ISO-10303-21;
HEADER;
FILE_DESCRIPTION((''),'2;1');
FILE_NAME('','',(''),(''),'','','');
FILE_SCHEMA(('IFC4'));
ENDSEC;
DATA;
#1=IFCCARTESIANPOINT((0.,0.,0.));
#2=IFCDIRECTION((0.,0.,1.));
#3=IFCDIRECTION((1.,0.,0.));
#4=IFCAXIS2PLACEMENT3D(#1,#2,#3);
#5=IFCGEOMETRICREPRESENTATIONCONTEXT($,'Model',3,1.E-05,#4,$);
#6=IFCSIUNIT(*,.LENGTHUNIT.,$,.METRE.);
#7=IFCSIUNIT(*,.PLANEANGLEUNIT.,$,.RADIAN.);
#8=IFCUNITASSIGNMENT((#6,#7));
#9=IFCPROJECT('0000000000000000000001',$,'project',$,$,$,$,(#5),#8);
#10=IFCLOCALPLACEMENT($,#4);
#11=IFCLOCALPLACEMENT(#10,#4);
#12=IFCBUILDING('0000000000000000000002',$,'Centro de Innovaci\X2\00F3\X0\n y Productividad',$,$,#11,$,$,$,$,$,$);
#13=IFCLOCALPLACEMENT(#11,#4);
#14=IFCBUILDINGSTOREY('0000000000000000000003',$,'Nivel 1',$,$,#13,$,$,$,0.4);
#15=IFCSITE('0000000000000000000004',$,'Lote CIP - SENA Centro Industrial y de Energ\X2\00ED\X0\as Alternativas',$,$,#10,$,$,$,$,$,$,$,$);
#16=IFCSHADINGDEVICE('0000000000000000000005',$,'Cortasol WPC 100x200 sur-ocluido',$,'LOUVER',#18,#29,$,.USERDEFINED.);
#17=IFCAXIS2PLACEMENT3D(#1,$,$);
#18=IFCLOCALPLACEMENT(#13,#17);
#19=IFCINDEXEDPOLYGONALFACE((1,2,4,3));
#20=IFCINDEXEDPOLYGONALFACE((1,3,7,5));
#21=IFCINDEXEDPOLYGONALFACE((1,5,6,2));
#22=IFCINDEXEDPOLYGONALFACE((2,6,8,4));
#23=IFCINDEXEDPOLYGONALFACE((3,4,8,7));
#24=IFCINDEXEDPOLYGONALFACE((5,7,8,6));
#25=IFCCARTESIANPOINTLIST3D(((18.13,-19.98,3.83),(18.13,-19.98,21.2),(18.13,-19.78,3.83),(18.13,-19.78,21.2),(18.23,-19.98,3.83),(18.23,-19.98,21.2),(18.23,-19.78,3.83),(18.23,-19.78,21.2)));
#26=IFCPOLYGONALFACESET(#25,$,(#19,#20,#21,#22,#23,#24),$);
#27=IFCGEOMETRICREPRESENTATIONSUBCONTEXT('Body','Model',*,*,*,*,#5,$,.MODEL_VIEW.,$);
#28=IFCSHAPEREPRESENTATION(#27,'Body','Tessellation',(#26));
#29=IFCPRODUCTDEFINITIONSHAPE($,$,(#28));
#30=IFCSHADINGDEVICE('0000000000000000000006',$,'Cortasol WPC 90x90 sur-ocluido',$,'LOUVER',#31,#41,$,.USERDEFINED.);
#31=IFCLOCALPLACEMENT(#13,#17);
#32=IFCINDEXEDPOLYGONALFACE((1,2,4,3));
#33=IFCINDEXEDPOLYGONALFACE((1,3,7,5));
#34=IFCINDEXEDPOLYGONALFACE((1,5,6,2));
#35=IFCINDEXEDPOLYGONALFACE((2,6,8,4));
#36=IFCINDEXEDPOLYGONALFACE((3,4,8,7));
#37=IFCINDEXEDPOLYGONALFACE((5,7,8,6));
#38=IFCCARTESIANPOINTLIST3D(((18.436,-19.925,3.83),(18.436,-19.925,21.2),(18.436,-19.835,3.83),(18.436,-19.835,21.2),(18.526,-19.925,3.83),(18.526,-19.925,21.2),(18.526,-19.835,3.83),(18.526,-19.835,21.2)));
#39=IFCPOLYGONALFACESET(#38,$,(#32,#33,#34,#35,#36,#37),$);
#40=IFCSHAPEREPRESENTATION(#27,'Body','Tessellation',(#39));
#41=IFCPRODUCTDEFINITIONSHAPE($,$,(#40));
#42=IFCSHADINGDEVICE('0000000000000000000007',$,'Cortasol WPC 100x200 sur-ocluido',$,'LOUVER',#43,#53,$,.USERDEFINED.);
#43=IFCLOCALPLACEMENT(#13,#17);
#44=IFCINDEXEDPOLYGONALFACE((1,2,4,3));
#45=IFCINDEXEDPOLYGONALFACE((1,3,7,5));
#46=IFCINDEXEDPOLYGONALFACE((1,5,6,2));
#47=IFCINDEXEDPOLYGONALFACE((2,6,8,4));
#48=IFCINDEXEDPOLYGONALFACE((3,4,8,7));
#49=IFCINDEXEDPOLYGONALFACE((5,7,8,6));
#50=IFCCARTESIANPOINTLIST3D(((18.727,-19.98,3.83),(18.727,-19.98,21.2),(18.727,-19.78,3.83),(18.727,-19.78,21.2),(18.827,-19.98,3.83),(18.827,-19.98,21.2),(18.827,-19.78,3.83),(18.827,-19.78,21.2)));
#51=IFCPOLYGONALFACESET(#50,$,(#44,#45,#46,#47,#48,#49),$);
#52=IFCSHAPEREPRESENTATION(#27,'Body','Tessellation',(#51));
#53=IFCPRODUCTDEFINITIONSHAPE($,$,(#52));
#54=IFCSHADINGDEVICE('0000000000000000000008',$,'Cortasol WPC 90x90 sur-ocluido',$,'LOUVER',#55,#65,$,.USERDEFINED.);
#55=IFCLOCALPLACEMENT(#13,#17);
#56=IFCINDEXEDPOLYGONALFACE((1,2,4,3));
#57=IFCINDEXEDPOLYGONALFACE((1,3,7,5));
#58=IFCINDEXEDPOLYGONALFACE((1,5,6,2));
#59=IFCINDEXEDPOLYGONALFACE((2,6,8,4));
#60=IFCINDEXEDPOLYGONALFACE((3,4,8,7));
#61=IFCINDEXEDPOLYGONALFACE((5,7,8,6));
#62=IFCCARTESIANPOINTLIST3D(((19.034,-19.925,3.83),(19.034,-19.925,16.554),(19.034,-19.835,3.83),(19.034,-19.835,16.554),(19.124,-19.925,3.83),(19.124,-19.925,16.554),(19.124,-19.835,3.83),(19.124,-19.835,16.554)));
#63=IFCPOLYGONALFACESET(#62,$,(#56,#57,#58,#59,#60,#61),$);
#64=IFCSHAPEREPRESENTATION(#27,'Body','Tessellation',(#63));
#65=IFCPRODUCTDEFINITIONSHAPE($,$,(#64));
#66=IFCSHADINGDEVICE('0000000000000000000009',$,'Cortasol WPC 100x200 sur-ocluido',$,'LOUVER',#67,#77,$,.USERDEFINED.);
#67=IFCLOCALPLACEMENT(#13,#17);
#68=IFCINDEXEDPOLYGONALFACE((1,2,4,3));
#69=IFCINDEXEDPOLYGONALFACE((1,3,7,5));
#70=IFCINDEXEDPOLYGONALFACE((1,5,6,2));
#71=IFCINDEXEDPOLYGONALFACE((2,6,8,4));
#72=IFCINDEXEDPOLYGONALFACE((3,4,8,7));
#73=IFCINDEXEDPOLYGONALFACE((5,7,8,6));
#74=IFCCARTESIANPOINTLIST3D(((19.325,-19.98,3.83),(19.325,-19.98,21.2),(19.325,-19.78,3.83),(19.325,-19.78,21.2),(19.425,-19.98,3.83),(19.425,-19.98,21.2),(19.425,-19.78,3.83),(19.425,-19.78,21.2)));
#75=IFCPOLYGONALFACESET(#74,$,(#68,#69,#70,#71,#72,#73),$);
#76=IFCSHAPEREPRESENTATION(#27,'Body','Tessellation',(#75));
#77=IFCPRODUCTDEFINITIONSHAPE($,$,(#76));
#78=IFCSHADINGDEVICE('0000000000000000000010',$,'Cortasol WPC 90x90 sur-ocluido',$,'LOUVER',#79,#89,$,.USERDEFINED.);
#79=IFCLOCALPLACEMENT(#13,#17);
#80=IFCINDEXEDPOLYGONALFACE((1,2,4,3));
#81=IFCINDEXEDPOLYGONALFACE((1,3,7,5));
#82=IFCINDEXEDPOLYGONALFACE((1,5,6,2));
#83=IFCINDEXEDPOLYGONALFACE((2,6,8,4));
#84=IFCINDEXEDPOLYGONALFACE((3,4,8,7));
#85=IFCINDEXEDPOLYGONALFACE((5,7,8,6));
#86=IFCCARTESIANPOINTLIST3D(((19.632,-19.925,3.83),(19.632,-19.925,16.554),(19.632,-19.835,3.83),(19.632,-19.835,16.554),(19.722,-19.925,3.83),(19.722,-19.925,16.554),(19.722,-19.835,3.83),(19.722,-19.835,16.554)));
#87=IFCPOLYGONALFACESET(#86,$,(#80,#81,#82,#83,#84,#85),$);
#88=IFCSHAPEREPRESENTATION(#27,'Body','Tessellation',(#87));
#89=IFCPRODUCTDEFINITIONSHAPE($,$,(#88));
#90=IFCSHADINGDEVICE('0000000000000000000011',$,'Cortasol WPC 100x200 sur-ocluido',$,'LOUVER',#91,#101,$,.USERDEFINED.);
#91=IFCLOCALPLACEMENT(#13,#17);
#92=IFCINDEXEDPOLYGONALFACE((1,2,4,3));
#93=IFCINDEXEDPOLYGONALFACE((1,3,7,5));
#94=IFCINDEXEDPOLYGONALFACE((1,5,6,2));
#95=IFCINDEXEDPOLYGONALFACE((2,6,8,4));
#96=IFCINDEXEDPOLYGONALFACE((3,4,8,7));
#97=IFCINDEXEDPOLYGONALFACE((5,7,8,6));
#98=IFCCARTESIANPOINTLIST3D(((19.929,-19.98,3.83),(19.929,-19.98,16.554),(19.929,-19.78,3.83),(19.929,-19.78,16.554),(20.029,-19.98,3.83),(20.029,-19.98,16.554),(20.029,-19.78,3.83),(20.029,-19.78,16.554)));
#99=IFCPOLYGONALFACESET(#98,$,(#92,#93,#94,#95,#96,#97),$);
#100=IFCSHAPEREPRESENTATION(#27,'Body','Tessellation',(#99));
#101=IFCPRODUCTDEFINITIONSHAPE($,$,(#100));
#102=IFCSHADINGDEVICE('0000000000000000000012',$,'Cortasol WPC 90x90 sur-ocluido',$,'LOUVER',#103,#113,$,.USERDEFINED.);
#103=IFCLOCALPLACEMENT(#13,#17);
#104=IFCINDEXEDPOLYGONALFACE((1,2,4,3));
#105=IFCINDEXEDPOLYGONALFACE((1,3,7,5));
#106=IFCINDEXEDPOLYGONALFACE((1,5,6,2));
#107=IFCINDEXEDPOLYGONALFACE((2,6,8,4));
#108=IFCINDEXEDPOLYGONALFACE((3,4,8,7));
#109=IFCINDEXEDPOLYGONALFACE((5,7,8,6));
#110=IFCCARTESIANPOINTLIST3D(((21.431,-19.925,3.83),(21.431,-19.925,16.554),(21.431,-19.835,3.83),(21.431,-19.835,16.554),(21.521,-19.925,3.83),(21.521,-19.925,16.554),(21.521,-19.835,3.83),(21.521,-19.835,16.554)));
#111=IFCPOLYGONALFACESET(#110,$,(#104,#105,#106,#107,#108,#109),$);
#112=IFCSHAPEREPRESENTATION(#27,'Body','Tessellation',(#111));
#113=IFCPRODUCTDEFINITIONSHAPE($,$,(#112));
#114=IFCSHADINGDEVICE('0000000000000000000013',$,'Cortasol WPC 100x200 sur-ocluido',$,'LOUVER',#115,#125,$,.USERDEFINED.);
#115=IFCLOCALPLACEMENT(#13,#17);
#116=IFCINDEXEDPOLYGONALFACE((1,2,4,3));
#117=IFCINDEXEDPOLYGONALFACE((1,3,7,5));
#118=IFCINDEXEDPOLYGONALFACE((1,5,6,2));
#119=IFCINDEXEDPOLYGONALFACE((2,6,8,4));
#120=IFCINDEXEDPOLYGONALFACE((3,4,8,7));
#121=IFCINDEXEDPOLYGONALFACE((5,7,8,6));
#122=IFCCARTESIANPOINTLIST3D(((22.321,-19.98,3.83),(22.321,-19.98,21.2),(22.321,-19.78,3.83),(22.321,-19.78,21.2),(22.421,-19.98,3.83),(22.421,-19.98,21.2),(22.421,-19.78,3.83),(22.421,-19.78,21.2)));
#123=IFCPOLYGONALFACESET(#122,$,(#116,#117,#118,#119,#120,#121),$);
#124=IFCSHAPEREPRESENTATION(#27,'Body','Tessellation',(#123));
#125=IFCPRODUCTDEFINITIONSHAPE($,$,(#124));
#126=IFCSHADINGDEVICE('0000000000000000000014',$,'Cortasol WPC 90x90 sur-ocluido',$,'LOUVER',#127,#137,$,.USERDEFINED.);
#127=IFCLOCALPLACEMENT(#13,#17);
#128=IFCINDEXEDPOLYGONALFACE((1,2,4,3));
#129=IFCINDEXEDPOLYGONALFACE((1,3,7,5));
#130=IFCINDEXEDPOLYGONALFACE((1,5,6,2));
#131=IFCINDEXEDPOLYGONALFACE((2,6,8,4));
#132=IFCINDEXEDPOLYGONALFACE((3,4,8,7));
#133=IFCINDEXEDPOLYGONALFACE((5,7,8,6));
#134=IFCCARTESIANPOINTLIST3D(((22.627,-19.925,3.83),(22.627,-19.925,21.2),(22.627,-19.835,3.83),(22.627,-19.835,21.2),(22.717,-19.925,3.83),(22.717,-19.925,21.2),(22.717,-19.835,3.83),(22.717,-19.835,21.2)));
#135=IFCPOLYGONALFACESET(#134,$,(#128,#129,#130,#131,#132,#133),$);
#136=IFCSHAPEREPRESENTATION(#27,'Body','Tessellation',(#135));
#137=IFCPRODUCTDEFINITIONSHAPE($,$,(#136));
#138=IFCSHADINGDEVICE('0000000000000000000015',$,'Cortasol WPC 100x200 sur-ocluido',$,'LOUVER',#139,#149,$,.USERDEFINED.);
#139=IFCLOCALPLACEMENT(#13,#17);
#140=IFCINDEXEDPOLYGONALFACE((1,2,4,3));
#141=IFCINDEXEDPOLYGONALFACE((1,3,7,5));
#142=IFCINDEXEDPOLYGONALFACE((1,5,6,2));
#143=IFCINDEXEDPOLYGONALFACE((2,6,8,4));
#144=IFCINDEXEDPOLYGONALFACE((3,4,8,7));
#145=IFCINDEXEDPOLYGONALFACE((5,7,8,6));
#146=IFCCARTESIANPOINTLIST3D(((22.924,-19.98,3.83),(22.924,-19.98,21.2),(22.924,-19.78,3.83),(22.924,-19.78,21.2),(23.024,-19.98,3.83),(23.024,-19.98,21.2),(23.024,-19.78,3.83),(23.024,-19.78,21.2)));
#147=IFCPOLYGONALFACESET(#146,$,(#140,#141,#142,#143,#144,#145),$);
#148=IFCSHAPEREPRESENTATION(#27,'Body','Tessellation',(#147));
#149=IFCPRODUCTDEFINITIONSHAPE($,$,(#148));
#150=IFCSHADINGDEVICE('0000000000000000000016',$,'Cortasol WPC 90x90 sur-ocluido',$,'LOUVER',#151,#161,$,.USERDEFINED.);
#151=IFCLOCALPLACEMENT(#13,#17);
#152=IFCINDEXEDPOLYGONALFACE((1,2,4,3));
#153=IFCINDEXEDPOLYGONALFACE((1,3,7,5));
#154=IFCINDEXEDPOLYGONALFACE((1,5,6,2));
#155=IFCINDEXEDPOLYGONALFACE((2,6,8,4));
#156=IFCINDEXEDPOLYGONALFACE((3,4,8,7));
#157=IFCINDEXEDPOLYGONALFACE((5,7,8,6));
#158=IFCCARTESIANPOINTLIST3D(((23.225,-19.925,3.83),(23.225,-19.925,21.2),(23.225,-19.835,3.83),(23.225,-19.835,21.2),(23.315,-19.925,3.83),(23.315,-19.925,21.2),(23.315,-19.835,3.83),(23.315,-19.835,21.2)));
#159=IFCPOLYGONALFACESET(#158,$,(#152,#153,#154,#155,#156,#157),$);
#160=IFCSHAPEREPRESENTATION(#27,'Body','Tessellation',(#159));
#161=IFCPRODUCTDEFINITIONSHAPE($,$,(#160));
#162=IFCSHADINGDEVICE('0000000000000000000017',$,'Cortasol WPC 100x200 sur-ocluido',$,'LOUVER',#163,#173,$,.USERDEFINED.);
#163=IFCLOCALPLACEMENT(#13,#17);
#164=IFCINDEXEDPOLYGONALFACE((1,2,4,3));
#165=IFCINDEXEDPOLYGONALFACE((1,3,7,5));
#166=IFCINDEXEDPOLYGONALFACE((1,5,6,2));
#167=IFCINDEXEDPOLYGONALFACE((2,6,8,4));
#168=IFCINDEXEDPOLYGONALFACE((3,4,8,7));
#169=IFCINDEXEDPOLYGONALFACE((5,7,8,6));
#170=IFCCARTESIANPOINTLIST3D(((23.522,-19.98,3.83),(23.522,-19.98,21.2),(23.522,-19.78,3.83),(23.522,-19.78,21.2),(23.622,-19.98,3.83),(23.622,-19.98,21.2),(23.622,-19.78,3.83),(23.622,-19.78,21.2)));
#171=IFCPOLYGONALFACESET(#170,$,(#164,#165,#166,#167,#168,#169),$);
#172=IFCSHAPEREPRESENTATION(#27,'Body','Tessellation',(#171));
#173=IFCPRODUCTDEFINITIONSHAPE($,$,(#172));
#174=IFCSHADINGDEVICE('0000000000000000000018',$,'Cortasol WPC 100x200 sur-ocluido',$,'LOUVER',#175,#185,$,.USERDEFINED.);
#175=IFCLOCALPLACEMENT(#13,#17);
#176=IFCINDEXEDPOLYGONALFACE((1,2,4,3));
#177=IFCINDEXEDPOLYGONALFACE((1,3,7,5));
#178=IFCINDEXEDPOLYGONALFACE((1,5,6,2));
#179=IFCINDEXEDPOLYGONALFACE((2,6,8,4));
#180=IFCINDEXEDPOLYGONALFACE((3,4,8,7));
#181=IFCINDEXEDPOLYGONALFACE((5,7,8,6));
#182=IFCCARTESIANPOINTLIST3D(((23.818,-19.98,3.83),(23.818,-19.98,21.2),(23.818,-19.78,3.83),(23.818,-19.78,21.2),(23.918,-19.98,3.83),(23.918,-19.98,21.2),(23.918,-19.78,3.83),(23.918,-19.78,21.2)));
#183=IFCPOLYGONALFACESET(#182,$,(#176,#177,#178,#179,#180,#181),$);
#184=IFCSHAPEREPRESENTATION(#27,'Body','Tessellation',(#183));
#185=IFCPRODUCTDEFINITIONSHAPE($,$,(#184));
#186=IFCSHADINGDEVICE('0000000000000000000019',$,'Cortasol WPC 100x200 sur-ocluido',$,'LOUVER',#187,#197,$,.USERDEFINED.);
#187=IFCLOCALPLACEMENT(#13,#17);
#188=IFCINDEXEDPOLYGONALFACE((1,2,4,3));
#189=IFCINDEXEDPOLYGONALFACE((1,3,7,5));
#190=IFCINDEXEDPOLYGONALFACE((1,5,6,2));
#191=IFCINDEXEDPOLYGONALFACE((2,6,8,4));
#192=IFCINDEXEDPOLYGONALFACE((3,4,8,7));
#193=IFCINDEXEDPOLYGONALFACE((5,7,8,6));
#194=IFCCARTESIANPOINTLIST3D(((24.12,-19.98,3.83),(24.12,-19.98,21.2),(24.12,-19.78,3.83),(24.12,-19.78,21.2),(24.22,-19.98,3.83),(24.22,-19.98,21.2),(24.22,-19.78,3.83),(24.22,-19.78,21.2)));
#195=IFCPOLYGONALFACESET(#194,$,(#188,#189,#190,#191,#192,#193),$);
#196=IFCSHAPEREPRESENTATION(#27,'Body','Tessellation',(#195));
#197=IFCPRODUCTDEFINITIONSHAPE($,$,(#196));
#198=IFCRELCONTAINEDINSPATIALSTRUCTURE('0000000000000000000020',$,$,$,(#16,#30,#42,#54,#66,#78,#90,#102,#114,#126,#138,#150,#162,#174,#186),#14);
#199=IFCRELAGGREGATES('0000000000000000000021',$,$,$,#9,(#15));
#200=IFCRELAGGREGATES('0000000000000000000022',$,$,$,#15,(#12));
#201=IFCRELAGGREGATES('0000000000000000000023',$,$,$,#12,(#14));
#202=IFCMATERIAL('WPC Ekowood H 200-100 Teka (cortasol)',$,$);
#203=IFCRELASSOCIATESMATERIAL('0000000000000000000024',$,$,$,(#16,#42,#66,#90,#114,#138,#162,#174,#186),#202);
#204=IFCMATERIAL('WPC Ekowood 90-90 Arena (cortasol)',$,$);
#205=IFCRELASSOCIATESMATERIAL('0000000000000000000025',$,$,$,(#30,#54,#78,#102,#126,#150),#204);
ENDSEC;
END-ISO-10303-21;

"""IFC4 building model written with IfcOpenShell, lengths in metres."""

from ifc_helpers import new_model, si_unit, frame, origin_with_axes, place, context, subcontext, project, spatial, polyline, outline, extrude, material, element, save


model = new_model("IFC4")

# Units and contexts
model_context = context("Model", 3, precision=1e-05, world=origin_with_axes())
body_context = subcontext(model_context, "Body", "Model", "MODEL_VIEW")
ifc_project = project(units=[si_unit("LENGTHUNIT", "METRE"), si_unit("PLANEANGLEUNIT", "RADIAN")], contexts=[model_context])

# Site, building, storey
site_placement = place(None, origin_with_axes())
site = spatial("IfcSite", under=ifc_project, at=site_placement, Name="Lote CIP - SENA Centro Industrial y de Energías Alternativas")
building_placement = place(site_placement, origin_with_axes())
building = spatial("IfcBuilding", under=site, at=building_placement, Name="Centro de Innovación y Productividad")
storey_placement = place(building_placement, origin_with_axes())
storey = spatial("IfcBuildingStorey", under=building, at=storey_placement, Name="Nivel 1", Elevation=0.4)

# Shading devices
ifc_material_1 = material(Name="WPC Ekowood H 200-100 Teka (cortasol)")
shading_device_1_placement = place(storey_placement, origin_with_axes())
element("IfcShadingDevice", 1, at=shading_device_1_placement, inside=storey, material=ifc_material_1, Name="Cortasol WPC 100x200 sur-ocluido", ObjectType="LOUVER", PredefinedType="USERDEFINED", context=body_context, shape_type="SweptSolid", body=[
    extrude(outline(polyline([(18.13, -19.98), (18.13, -19.78), (18.23, -19.78), (18.23, -19.98), (18.13, -19.98)])), frame((0.0, 0.0, 3.83)), (0.0, 0.0, 1.0), 17.37),
])
ifc_material_2 = material(Name="WPC Ekowood 90-90 Arena (cortasol)")
shading_device_2_placement = place(storey_placement, origin_with_axes())
element("IfcShadingDevice", 2, at=shading_device_2_placement, inside=storey, material=ifc_material_2, Name="Cortasol WPC 90x90 sur-ocluido", ObjectType="LOUVER", PredefinedType="USERDEFINED", context=body_context, shape_type="SweptSolid", body=[
    extrude(outline(polyline([(18.436, -19.925), (18.436, -19.835), (18.526, -19.835), (18.526, -19.925), (18.436, -19.925)])), frame((0.0, 0.0, 3.83)), (0.0, 0.0, 1.0), 17.37),
])
shading_device_3_placement = place(storey_placement, origin_with_axes())
element("IfcShadingDevice", 3, at=shading_device_3_placement, inside=storey, material=ifc_material_1, Name="Cortasol WPC 100x200 sur-ocluido", ObjectType="LOUVER", PredefinedType="USERDEFINED", context=body_context, shape_type="SweptSolid", body=[
    extrude(outline(polyline([(18.727, -19.98), (18.727, -19.78), (18.827, -19.78), (18.827, -19.98), (18.727, -19.98)])), frame((0.0, 0.0, 3.83)), (0.0, 0.0, 1.0), 17.37),
])
shading_device_4_placement = place(storey_placement, origin_with_axes())
element("IfcShadingDevice", 4, at=shading_device_4_placement, inside=storey, material=ifc_material_2, Name="Cortasol WPC 90x90 sur-ocluido", ObjectType="LOUVER", PredefinedType="USERDEFINED", context=body_context, shape_type="SweptSolid", body=[
    extrude(outline(polyline([(19.034, -19.925), (19.034, -19.835), (19.124, -19.835), (19.124, -19.925), (19.034, -19.925)])), frame((0.0, 0.0, 3.83)), (0.0, 0.0, 1.0), 12.724),
])
shading_device_5_placement = place(storey_placement, origin_with_axes())
element("IfcShadingDevice", 5, at=shading_device_5_placement, inside=storey, material=ifc_material_1, Name="Cortasol WPC 100x200 sur-ocluido", ObjectType="LOUVER", PredefinedType="USERDEFINED", context=body_context, shape_type="SweptSolid", body=[
    extrude(outline(polyline([(19.325, -19.98), (19.325, -19.78), (19.425, -19.78), (19.425, -19.98), (19.325, -19.98)])), frame((0.0, 0.0, 3.83)), (0.0, 0.0, 1.0), 17.37),
])
shading_device_6_placement = place(storey_placement, origin_with_axes())
element("IfcShadingDevice", 6, at=shading_device_6_placement, inside=storey, material=ifc_material_2, Name="Cortasol WPC 90x90 sur-ocluido", ObjectType="LOUVER", PredefinedType="USERDEFINED", context=body_context, shape_type="SweptSolid", body=[
    extrude(outline(polyline([(19.632, -19.925), (19.632, -19.835), (19.722, -19.835), (19.722, -19.925), (19.632, -19.925)])), frame((0.0, 0.0, 3.83)), (0.0, 0.0, 1.0), 12.724),
])
shading_device_7_placement = place(storey_placement, origin_with_axes())
element("IfcShadingDevice", 7, at=shading_device_7_placement, inside=storey, material=ifc_material_1, Name="Cortasol WPC 100x200 sur-ocluido", ObjectType="LOUVER", PredefinedType="USERDEFINED", context=body_context, shape_type="SweptSolid", body=[
    extrude(outline(polyline([(19.929, -19.98), (19.929, -19.78), (20.029, -19.78), (20.029, -19.98), (19.929, -19.98)])), frame((0.0, 0.0, 3.83)), (0.0, 0.0, 1.0), 12.724),
])
shading_device_8_placement = place(storey_placement, origin_with_axes())
element("IfcShadingDevice", 8, at=shading_device_8_placement, inside=storey, material=ifc_material_2, Name="Cortasol WPC 90x90 sur-ocluido", ObjectType="LOUVER", PredefinedType="USERDEFINED", context=body_context, shape_type="SweptSolid", body=[
    extrude(outline(polyline([(21.431, -19.925), (21.431, -19.835), (21.521, -19.835), (21.521, -19.925), (21.431, -19.925)])), frame((0.0, 0.0, 3.83)), (0.0, 0.0, 1.0), 12.724),
])
shading_device_9_placement = place(storey_placement, origin_with_axes())
element("IfcShadingDevice", 9, at=shading_device_9_placement, inside=storey, material=ifc_material_1, Name="Cortasol WPC 100x200 sur-ocluido", ObjectType="LOUVER", PredefinedType="USERDEFINED", context=body_context, shape_type="SweptSolid", body=[
    extrude(outline(polyline([(22.321, -19.98), (22.321, -19.78), (22.421, -19.78), (22.421, -19.98), (22.321, -19.98)])), frame((0.0, 0.0, 3.83)), (0.0, 0.0, 1.0), 17.37),
])
shading_device_10_placement = place(storey_placement, origin_with_axes())
element("IfcShadingDevice", 10, at=shading_device_10_placement, inside=storey, material=ifc_material_2, Name="Cortasol WPC 90x90 sur-ocluido", ObjectType="LOUVER", PredefinedType="USERDEFINED", context=body_context, shape_type="SweptSolid", body=[
    extrude(outline(polyline([(22.627, -19.925), (22.627, -19.835), (22.717, -19.835), (22.717, -19.925), (22.627, -19.925)])), frame((0.0, 0.0, 3.83)), (0.0, 0.0, 1.0), 17.37),
])
shading_device_11_placement = place(storey_placement, origin_with_axes())
element("IfcShadingDevice", 11, at=shading_device_11_placement, inside=storey, material=ifc_material_1, Name="Cortasol WPC 100x200 sur-ocluido", ObjectType="LOUVER", PredefinedType="USERDEFINED", context=body_context, shape_type="SweptSolid", body=[
    extrude(outline(polyline([(22.924, -19.98), (22.924, -19.78), (23.024, -19.78), (23.024, -19.98), (22.924, -19.98)])), frame((0.0, 0.0, 3.83)), (0.0, 0.0, 1.0), 17.37),
])
shading_device_12_placement = place(storey_placement, origin_with_axes())
element("IfcShadingDevice", 12, at=shading_device_12_placement, inside=storey, material=ifc_material_2, Name="Cortasol WPC 90x90 sur-ocluido", ObjectType="LOUVER", PredefinedType="USERDEFINED", context=body_context, shape_type="SweptSolid", body=[
    extrude(outline(polyline([(23.225, -19.925), (23.225, -19.835), (23.315, -19.835), (23.315, -19.925), (23.225, -19.925)])), frame((0.0, 0.0, 3.83)), (0.0, 0.0, 1.0), 17.37),
])
shading_device_13_placement = place(storey_placement, origin_with_axes())
element("IfcShadingDevice", 13, at=shading_device_13_placement, inside=storey, material=ifc_material_1, Name="Cortasol WPC 100x200 sur-ocluido", ObjectType="LOUVER", PredefinedType="USERDEFINED", context=body_context, shape_type="SweptSolid", body=[
    extrude(outline(polyline([(23.522, -19.98), (23.522, -19.78), (23.622, -19.78), (23.622, -19.98), (23.522, -19.98)])), frame((0.0, 0.0, 3.83)), (0.0, 0.0, 1.0), 17.37),
])
shading_device_14_placement = place(storey_placement, origin_with_axes())
element("IfcShadingDevice", 14, at=shading_device_14_placement, inside=storey, material=ifc_material_1, Name="Cortasol WPC 100x200 sur-ocluido", ObjectType="LOUVER", PredefinedType="USERDEFINED", context=body_context, shape_type="SweptSolid", body=[
    extrude(outline(polyline([(23.818, -19.98), (23.818, -19.78), (23.918, -19.78), (23.918, -19.98), (23.818, -19.98)])), frame((0.0, 0.0, 3.83)), (0.0, 0.0, 1.0), 17.37),
])
shading_device_15_placement = place(storey_placement, origin_with_axes())
element("IfcShadingDevice", 15, at=shading_device_15_placement, inside=storey, material=ifc_material_1, Name="Cortasol WPC 100x200 sur-ocluido", ObjectType="LOUVER", PredefinedType="USERDEFINED", context=body_context, shape_type="SweptSolid", body=[
    extrude(outline(polyline([(24.12, -19.98), (24.12, -19.78), (24.22, -19.78), (24.22, -19.98), (24.12, -19.98)])), frame((0.0, 0.0, 3.83)), (0.0, 0.0, 1.0), 17.37),
])

save(model, "model.ifc")
